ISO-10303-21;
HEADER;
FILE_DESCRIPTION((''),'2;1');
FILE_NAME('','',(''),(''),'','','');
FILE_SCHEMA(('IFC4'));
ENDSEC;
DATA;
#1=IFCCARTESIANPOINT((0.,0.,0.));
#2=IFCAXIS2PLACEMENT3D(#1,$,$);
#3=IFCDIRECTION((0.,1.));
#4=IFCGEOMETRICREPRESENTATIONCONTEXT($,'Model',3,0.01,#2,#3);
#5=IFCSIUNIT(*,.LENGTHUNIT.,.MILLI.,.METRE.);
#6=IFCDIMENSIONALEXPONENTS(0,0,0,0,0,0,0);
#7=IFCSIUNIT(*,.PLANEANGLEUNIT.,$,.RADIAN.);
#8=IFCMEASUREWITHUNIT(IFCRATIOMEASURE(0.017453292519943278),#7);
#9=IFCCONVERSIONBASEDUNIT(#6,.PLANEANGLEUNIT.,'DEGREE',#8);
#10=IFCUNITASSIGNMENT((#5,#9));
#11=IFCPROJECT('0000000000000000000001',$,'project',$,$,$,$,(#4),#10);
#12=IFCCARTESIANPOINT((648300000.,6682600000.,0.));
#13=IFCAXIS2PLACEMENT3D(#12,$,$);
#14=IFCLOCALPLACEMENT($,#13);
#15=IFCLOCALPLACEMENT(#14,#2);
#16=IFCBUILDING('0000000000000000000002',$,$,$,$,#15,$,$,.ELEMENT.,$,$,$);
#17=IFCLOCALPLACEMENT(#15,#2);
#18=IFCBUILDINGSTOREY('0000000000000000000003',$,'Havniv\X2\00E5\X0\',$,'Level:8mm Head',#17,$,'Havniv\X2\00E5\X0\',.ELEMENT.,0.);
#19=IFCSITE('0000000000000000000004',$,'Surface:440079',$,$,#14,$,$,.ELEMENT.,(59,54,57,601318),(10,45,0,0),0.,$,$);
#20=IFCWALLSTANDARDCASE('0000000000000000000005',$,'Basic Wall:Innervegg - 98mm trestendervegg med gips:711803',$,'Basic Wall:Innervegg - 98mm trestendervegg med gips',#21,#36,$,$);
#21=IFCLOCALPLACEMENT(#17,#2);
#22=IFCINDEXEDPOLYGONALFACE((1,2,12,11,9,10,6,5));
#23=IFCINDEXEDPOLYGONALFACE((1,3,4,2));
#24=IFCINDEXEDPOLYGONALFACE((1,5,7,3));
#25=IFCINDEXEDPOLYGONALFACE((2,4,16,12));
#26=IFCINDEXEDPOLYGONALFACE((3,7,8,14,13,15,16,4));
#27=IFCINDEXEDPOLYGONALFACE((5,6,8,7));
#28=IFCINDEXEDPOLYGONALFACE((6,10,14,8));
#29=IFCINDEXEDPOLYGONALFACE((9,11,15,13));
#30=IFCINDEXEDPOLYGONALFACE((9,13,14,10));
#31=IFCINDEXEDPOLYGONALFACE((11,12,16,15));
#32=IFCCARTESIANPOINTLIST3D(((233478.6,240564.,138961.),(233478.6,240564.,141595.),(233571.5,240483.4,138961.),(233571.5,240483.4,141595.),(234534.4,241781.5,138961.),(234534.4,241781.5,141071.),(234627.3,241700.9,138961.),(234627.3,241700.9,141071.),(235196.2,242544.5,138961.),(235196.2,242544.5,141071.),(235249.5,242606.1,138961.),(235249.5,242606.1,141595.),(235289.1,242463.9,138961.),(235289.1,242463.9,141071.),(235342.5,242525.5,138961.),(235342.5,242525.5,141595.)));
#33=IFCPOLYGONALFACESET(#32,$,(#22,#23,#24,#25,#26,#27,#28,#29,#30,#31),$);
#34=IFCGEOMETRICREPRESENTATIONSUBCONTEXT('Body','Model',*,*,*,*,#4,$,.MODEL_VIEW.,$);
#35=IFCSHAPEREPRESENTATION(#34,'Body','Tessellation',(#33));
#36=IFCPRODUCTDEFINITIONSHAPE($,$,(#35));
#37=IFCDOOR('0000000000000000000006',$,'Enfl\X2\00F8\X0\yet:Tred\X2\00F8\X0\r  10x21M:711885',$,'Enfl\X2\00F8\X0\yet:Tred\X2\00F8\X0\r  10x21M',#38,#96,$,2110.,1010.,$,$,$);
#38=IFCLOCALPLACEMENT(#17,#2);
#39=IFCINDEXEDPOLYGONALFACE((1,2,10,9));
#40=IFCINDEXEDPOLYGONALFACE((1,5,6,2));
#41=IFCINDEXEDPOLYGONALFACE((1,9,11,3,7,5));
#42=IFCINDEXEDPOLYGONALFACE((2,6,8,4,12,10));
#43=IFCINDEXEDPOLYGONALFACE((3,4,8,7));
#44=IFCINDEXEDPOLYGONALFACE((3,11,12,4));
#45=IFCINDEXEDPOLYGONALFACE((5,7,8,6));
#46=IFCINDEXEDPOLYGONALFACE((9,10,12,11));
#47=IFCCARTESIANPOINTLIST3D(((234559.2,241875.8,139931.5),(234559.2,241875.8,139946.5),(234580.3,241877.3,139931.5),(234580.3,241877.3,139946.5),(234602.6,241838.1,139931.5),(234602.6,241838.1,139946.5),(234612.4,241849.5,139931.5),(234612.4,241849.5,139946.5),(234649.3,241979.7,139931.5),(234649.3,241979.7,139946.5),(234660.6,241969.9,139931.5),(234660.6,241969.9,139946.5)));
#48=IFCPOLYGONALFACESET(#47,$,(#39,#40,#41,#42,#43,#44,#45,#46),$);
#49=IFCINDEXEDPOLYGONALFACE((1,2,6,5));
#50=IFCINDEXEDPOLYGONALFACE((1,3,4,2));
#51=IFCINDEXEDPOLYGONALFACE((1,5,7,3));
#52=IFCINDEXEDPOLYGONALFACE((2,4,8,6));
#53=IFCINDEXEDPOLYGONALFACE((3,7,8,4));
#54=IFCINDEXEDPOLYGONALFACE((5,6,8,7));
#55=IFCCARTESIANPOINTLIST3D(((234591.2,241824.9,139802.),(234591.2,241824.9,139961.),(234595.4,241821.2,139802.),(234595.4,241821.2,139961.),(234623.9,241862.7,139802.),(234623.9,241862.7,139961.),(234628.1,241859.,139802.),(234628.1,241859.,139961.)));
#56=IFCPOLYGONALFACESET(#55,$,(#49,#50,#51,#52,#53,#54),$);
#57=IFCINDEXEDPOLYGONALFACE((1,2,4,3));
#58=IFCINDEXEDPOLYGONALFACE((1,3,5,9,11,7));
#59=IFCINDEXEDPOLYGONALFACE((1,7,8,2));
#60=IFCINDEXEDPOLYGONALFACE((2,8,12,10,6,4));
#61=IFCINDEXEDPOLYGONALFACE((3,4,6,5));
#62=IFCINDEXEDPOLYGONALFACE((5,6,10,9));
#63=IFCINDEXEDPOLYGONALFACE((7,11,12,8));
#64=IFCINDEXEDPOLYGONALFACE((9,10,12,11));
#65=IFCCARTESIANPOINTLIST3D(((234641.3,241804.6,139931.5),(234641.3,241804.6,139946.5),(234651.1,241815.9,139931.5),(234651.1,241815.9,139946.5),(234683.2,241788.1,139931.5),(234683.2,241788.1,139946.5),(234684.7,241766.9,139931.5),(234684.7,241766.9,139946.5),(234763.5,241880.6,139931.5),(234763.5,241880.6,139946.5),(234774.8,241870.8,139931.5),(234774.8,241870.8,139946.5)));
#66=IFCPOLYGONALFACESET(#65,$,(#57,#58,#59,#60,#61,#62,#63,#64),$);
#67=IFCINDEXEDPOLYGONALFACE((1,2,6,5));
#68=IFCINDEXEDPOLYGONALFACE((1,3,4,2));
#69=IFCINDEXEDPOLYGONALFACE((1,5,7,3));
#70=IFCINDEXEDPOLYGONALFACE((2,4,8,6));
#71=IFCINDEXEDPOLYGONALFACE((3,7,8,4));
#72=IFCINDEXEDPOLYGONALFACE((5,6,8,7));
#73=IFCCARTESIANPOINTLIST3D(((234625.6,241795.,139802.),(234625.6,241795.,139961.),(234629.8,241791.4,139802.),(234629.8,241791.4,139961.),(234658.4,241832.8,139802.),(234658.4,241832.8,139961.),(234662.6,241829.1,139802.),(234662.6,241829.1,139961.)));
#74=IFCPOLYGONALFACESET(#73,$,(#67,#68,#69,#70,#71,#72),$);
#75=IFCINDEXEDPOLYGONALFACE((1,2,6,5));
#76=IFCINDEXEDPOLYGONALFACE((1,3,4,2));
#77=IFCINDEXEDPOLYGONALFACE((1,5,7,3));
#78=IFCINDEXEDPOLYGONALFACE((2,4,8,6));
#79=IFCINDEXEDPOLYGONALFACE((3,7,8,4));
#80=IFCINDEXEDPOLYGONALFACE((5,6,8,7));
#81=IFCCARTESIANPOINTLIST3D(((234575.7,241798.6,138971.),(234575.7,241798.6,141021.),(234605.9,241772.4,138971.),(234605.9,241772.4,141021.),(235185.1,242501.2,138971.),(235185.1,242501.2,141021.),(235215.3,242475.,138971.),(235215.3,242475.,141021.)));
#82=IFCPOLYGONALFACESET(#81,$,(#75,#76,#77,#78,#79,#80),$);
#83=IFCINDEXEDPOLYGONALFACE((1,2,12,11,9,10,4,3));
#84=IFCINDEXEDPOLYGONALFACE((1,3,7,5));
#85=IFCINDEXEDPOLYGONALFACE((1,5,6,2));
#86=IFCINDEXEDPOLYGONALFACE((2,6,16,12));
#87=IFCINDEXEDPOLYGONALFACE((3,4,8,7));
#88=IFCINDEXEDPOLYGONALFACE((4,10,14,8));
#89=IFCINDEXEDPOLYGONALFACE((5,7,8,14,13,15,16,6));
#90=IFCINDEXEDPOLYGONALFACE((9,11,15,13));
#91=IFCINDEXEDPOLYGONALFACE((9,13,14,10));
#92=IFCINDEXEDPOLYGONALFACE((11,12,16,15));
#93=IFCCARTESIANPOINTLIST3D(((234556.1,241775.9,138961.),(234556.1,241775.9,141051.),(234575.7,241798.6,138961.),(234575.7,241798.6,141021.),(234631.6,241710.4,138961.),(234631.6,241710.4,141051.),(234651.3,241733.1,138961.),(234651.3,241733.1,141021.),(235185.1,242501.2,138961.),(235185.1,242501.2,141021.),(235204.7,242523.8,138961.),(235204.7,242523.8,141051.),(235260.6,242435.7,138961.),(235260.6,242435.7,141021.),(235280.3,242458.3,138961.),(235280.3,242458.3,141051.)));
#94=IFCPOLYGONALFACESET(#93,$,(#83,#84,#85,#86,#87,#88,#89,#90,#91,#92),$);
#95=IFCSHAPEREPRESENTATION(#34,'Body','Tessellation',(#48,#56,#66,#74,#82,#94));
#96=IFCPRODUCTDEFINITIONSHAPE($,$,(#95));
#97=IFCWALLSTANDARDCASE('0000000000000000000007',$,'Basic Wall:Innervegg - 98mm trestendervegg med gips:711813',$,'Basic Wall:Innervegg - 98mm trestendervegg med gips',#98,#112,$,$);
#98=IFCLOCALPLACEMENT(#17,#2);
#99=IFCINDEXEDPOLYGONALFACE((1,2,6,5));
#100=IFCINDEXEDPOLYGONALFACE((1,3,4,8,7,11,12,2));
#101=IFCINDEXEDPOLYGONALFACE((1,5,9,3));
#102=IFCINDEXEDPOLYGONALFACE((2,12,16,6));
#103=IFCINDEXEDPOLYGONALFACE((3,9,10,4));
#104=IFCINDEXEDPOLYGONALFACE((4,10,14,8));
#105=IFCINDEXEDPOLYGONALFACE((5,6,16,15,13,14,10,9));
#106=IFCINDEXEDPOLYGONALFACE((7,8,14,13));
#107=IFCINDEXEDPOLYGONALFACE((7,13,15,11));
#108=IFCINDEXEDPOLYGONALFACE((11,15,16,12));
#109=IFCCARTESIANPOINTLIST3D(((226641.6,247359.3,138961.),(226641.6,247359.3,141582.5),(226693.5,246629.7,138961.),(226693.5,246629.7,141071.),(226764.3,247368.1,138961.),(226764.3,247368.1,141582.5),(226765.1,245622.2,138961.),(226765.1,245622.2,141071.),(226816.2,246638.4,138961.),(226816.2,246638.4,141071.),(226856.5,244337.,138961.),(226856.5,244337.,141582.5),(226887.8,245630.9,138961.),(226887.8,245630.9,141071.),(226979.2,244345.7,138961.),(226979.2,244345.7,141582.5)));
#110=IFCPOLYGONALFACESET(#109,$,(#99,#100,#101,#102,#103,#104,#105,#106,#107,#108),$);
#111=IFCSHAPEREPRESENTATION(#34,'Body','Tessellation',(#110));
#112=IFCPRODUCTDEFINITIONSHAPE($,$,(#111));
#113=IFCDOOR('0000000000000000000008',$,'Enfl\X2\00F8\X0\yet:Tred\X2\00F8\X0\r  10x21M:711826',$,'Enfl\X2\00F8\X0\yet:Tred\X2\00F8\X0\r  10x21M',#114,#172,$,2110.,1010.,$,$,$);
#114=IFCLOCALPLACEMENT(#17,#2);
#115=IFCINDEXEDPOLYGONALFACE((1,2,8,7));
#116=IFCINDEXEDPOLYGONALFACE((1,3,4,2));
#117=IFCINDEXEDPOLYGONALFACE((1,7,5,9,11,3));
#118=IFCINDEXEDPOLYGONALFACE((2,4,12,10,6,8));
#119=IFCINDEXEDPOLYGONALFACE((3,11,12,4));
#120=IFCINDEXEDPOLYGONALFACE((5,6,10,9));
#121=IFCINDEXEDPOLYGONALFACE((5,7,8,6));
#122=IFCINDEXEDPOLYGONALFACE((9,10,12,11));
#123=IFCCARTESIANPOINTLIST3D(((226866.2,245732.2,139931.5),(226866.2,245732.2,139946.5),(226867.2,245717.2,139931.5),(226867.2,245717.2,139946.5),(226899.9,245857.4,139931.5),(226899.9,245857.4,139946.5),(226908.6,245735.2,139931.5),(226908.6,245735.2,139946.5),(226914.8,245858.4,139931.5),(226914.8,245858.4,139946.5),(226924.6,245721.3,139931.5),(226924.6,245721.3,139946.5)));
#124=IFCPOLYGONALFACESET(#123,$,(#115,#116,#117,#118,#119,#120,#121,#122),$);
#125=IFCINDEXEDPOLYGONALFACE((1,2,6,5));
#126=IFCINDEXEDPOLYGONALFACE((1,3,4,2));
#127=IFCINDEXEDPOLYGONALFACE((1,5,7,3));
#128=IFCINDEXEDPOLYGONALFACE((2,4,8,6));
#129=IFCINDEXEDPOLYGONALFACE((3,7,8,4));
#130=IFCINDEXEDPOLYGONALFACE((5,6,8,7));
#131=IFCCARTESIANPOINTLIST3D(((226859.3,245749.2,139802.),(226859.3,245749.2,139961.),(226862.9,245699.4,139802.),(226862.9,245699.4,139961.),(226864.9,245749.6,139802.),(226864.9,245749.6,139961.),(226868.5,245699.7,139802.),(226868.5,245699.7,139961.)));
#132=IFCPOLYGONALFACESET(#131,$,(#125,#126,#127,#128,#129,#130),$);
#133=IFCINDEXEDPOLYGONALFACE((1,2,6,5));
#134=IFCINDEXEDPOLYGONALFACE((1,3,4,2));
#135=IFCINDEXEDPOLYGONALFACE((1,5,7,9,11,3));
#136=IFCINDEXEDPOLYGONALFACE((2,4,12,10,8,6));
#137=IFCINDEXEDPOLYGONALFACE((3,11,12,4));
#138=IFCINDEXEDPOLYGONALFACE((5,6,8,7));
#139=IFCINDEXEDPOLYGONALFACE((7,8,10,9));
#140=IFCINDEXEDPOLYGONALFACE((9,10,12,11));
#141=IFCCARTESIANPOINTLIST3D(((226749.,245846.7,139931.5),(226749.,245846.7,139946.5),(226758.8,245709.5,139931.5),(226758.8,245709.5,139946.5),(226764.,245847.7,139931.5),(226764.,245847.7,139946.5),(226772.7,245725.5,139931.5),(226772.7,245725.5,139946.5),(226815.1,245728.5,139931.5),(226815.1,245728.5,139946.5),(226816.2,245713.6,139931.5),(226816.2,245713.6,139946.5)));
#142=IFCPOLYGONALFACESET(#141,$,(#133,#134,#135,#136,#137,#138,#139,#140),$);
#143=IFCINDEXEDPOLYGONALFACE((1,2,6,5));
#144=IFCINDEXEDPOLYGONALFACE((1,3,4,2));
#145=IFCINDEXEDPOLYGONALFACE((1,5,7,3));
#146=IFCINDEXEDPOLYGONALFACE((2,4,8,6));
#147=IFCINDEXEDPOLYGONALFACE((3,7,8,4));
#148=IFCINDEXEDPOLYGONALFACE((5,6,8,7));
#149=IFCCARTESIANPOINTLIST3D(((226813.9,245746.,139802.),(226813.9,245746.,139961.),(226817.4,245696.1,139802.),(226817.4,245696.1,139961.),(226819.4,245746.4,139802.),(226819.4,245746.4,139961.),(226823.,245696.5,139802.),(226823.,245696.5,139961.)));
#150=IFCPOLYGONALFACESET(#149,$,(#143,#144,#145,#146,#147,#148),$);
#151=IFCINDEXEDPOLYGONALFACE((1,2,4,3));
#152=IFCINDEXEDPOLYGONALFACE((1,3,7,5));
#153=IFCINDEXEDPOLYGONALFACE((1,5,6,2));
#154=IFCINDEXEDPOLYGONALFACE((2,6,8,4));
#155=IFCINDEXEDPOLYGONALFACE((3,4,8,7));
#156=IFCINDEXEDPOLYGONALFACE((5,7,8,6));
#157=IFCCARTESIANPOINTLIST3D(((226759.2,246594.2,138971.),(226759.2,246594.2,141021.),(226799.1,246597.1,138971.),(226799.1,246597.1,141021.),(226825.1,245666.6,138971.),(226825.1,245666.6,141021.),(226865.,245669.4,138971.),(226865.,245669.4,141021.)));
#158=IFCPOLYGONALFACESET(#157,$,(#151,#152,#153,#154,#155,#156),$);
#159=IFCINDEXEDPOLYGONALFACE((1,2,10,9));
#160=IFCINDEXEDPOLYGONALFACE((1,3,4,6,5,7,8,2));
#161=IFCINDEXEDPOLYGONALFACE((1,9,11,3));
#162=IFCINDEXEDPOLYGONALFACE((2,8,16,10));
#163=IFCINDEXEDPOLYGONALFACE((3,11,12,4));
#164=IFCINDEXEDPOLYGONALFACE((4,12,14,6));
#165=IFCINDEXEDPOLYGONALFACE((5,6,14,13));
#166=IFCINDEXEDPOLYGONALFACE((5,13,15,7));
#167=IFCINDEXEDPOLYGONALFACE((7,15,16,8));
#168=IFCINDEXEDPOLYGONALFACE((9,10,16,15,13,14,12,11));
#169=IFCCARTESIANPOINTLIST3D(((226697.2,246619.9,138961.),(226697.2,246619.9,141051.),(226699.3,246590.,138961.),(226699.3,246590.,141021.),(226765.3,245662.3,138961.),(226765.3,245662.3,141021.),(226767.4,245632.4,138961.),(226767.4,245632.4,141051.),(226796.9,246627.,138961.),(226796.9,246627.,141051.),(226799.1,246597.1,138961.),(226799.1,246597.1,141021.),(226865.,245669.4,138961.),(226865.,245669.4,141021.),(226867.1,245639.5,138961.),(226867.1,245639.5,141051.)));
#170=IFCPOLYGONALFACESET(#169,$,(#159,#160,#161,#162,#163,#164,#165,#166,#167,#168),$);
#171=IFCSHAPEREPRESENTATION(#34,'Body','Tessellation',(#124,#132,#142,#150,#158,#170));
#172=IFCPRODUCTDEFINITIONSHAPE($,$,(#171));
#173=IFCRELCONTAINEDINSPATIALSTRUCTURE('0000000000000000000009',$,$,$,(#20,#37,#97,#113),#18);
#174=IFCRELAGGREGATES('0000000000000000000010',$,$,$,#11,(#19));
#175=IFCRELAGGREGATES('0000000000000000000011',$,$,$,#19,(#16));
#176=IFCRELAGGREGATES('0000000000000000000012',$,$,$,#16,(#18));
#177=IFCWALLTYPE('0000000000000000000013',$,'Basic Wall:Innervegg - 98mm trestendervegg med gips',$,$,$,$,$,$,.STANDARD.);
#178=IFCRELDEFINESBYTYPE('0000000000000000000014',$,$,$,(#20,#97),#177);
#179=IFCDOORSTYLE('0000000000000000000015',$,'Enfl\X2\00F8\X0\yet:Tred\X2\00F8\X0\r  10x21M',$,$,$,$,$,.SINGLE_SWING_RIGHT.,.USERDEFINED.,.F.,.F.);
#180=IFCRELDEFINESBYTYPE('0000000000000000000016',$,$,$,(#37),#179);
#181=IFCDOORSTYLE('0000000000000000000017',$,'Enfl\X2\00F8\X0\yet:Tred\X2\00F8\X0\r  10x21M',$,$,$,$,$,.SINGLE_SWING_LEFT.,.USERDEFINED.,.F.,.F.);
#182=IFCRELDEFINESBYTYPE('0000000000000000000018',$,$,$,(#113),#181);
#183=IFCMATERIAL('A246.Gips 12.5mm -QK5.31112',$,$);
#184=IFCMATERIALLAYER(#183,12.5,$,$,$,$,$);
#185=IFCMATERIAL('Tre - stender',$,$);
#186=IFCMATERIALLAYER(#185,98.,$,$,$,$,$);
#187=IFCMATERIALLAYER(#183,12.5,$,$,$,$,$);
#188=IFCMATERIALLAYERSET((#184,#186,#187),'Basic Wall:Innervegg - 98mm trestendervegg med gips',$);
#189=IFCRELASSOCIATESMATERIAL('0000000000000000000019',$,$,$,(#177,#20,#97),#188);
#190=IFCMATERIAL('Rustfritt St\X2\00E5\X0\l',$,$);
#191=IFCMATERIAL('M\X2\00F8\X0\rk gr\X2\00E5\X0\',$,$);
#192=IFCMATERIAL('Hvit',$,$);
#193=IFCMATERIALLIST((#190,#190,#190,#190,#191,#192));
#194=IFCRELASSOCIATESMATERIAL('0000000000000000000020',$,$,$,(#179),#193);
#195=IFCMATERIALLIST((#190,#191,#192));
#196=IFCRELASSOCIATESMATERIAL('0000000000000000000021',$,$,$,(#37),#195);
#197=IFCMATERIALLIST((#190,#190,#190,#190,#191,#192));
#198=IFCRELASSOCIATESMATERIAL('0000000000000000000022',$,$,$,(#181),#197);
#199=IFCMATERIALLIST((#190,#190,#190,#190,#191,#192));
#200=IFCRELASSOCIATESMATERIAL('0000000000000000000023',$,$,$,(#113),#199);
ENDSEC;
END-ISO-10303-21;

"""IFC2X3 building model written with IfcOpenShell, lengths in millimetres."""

from ifc_helpers import new_model, entity, si_unit, converted_unit, direction, frame, frame_2d, origin, origin_2d_with_axis, place, context, subcontext, project, spatial, polyline, rectangle, outline, extrude, clip, bounded_halfspace, source, transform, mapped, material, material_list, layer, layer_set, layer_usage, type_object, type_shapes, element, fill, save


model = new_model("IFC2X3")

# Units and contexts
model_context = context("Model", 3, precision=0.01, world=origin(), true_north=direction((0.0, 1.0)))
body_context = subcontext(model_context, "Body", "Model", "MODEL_VIEW")
ifc_project = project(units=[si_unit("LENGTHUNIT", "METRE", prefix="MILLI"), converted_unit("PLANEANGLEUNIT", "DEGREE", entity("IfcRatioMeasure", 0.017453292519943278), si_unit("PLANEANGLEUNIT", "RADIAN"), dimensions=[0, 0, 0, 0, 0, 0, 0])], contexts=[model_context])

# Site, building, storey
site_placement = place(None, frame((648300000.0, 6682600000.0, 0.0)))
site = spatial("IfcSite", under=ifc_project, at=site_placement, Name="Surface:440079", CompositionType="ELEMENT", RefLatitude=(59, 54, 57, 601318), RefLongitude=(10, 45, 0, 0), RefElevation=0.0)
building_placement = place(site_placement, origin())
building = spatial("IfcBuilding", under=site, at=building_placement, CompositionType="ELEMENT")
storey_placement = place(building_placement, origin())
storey = spatial("IfcBuildingStorey", under=building, at=storey_placement, Name="Havnivå", ObjectType="Level:8mm Head", LongName="Havnivå", CompositionType="ELEMENT", Elevation=0.0)

# Shared definitions
ifc_material_1 = material(Name="A246.Gips 12.5mm -QK5.31112")
ifc_layer_1 = layer(ifc_material_1, 12.5)
ifc_material_2 = material(Name="Tre - stender")
ifc_layer_2 = layer(ifc_material_2, 98.0)
ifc_layer_3 = layer(ifc_material_1, 12.5)
ifc_layer_set = layer_set([ifc_layer_1, ifc_layer_2, ifc_layer_3], Name="Basic Wall:Innervegg - 98mm trestendervegg med gips")
wall_type = type_object("IfcWallType", Name="Basic Wall:Innervegg - 98mm trestendervegg med gips", PredefinedType="STANDARD", material=ifc_layer_set)
ifc_material_3 = material(Name="Rustfritt Stål")
ifc_material_4 = material(Name="Mørk grå")
ifc_material_5 = material(Name="Hvit")
ifc_material_list_1 = material_list([ifc_material_3, ifc_material_3, ifc_material_3, ifc_material_3, ifc_material_4, ifc_material_5])
door_style_1 = type_object("IfcDoorStyle", Name="Enfløyet:Tredør  10x21M", ConstructionType="USERDEFINED", OperationType="SINGLE_SWING_RIGHT", ParameterTakesPrecedence=False, Sizeable=False, material=ifc_material_list_1)
shared_shape_1 = source(origin(), body_context, "Body", "SweptSolid", [
    extrude(outline(polyline([(-50.8, -33.3), (-35.8, -33.3), (-35.8, 9.2), (86.7, 9.2), (86.7, 24.2), (-50.8, 24.2), (-50.8, -33.3)])), frame((138.3, 141.9, 970.5)), (0.0, 0.0, 1.0), 15.0),
    extrude(rectangle(XDim=50.0, YDim=5.6, at=frame_2d((0.0, 0.0), x_axis=(1.0, 0.0))), frame((95.0, 105.8, 841.0), z_axis=(0.0, 0.0, 1.0), x_axis=(-1.0, 0.0, 0.0)), (0.0, 0.0, 1.0), 159.0),
    extrude(outline(polyline([(-33.3, -50.8), (24.2, -50.8), (24.2, 86.7), (9.2, 86.7), (9.2, -35.8), (-33.3, -35.8), (-33.3, -50.8)])), frame((138.3, 24.1, 970.5), z_axis=(0.0, 0.0, 1.0), x_axis=(0.0, -1.0, 0.0)), (0.0, 0.0, 1.0), 15.0),
    extrude(rectangle(XDim=5.6, YDim=50.0, at=frame_2d((0.0, 0.0), x_axis=(1.0, 0.0))), frame((95.0, 60.2, 841.0), z_axis=(0.0, 0.0, 1.0), x_axis=(0.0, 1.0, 0.0)), (0.0, 0.0, 1.0), 159.0),
    extrude(rectangle(XDim=40.0, YDim=930.0, at=origin_2d_with_axis()), frame((505.0, 83.0, 10.0), z_axis=(0.0, 0.0, 1.0), x_axis=(0.0, -1.0, 0.0)), (0.0, 0.0, 1.0), 2050.0),
    extrude(outline(polyline([(-1037.5, -495.0), (1052.5, -495.0), (1052.5, 495.0), (-1037.5, 495.0), (-1037.5, 465.0), (1022.5, 465.0), (1022.5, -465.0), (-1037.5, -465.0), (-1037.5, -495.0)])), frame((505.0, 3.0, 1037.5), z_axis=(0.0, 1.0, 0.0), x_axis=(0.0, 0.0, 1.0)), (0.0, 0.0, 1.0), 100.0),
])
type_shapes(door_style_1, [shared_shape_1])

# Wall, opening, door
ifc_layer_usage_1 = layer_usage(ifc_layer_set, "AXIS2", "NEGATIVE", 61.5)
wall_1_placement = place(storey_placement, frame((235296.0, 242565.8, 138961.0), z_axis=(0.0, 0.0, 1.0), x_axis=(-0.655187, -0.755467, 0.0)))
wall_1 = element("IfcWallStandardCase", 1, at=wall_1_placement, inside=storey, type_object=wall_type, material=ifc_layer_usage_1, Name="Basic Wall:Innervegg - 98mm trestendervegg med gips:711803", ObjectType="Basic Wall:Innervegg - 98mm trestendervegg med gips", context=body_context, shape_type="SweptSolid", body=[
    extrude(rectangle(XDim=2703.0, YDim=123.0, at=frame_2d((1351.5, 0.0), x_axis=(1.0, 0.0))), origin(), (0.0, 0.0, 1.0), 2634.0),
])
opening_1_placement = place(wall_1_placement, frame((1091.5, 61.5, 0.0)))
opening_1 = element("IfcOpeningElement", 2, at=opening_1_placement, cuts=wall_1, ObjectType="Opening", context=body_context, shape_type="SweptSolid", body=[
    extrude(rectangle(XDim=2110.0, YDim=1010.0, at=frame_2d((1055.0, 505.0), x_axis=(1.0, 0.0))), frame((0.0, 0.0, 0.0), z_axis=(0.0, -1.0, 0.0), x_axis=(0.0, 0.0, 1.0)), (0.0, 0.0, 1.0), 123.0),
])
ifc_material_list_2 = material_list([ifc_material_3, ifc_material_4, ifc_material_5])
door_1_placement = place(opening_1_placement, frame((0.0, 0.0, 0.0), z_axis=(0.0, 0.0, 1.0), x_axis=(-1.0, 0.0, 0.0)))
door_1 = element("IfcDoor", 3, at=door_1_placement, inside=storey, type_object=door_style_1, material=ifc_material_list_2, Name="Enfløyet:Tredør  10x21M:711885", ObjectType="Enfløyet:Tredør  10x21M", OverallHeight=2110.0, OverallWidth=1010.0, context=body_context, shape_type="MappedRepresentation", body=[
    mapped(shared_shape_1, transform((0.0, 0.0, 0.0), scale=1.0)),
])
fill(opening_1, door_1)

# Wall, opening, door
ifc_layer_usage_2 = layer_usage(ifc_layer_set, "AXIS2", "NEGATIVE", 61.5)
wall_2_placement = place(storey_placement, frame((226703.0, 247363.7, 138961.0), z_axis=(0.0, 0.0, 1.0), x_axis=(0.070908, -0.997483, 0.0)))
wall_2 = element("IfcWallStandardCase", 4, at=wall_2_placement, inside=storey, type_object=wall_type, material=ifc_layer_usage_2, Name="Basic Wall:Innervegg - 98mm trestendervegg med gips:711813", ObjectType="Basic Wall:Innervegg - 98mm trestendervegg med gips", context=body_context, shape_type="Clipping", body=[
    clip(extrude(rectangle(XDim=3030.0, YDim=123.0, at=frame_2d((1515.0, 0.0), x_axis=(1.0, 0.0))), origin(), (0.0, 0.0, 1.0), 2621.5), bounded_halfspace(frame((0.0, -61.5, 2621.5), z_axis=(0.0, 0.0, -1.0), x_axis=(0.0, 1.0, 0.0)), True, frame((0.0, -61.5, 2621.5)), polyline([(0.0, 0.0), (557784.0, 0.0), (595274.4, 0.0), (923544.0, 0.0), (923544.0, 37490.4), (0.0, 37490.4), (0.0, 0.0)]))),
])
opening_2_placement = place(wall_2_placement, frame((731.5, -61.5, 0.0)))
opening_2 = element("IfcOpeningElement", 5, at=opening_2_placement, cuts=wall_2, ObjectType="Opening", context=body_context, shape_type="SweptSolid", body=[
    extrude(rectangle(XDim=2110.0, YDim=1010.0, at=frame_2d((1055.0, 505.0), x_axis=(1.0, 0.0))), frame((0.0, 0.0, 0.0), z_axis=(0.0, 1.0, 0.0), x_axis=(0.0, 0.0, 1.0)), (0.0, 0.0, 1.0), 123.0),
])
ifc_material_list_3 = material_list([ifc_material_3, ifc_material_3, ifc_material_3, ifc_material_3, ifc_material_4, ifc_material_5])
ifc_material_list_4 = material_list([ifc_material_3, ifc_material_3, ifc_material_3, ifc_material_3, ifc_material_4, ifc_material_5])
door_style_2 = type_object("IfcDoorStyle", Name="Enfløyet:Tredør  10x21M", ConstructionType="USERDEFINED", OperationType="SINGLE_SWING_LEFT", ParameterTakesPrecedence=False, Sizeable=False, material=ifc_material_list_4)
shared_shape_2 = source(origin(), body_context, "Body", "SweptSolid", [
    extrude(outline(polyline([(-33.3, -50.8), (24.2, -50.8), (24.2, 86.7), (9.2, 86.7), (9.2, -35.8), (-33.3, -35.8), (-33.3, -50.8)])), frame((871.7, 121.9, 970.5), z_axis=(0.0, 0.0, 1.0), x_axis=(0.0, 1.0, 0.0)), (0.0, 0.0, 1.0), 15.0),
    extrude(rectangle(XDim=5.6, YDim=50.0, at=frame_2d((0.0, 0.0), x_axis=(1.0, 0.0))), frame((915.0, 85.8, 841.0), z_axis=(0.0, 0.0, 1.0), x_axis=(0.0, -1.0, 0.0)), (0.0, 0.0, 1.0), 159.0),
    extrude(outline(polyline([(-50.8, -33.3), (-35.8, -33.3), (-35.8, 9.2), (86.7, 9.2), (86.7, 24.2), (-50.8, 24.2), (-50.8, -33.3)])), frame((871.7, 4.1, 970.5), z_axis=(0.0, 0.0, 1.0), x_axis=(-1.0, 0.0, 0.0)), (0.0, 0.0, 1.0), 15.0),
    extrude(rectangle(XDim=50.0, YDim=5.6, at=frame_2d((0.0, 0.0), x_axis=(1.0, 0.0))), frame((915.0, 40.2, 841.0)), (0.0, 0.0, 1.0), 159.0),
    extrude(rectangle(XDim=930.0, YDim=40.0, at=origin_2d_with_axis()), frame((505.0, 63.0, 10.0), z_axis=(0.0, 0.0, 1.0), x_axis=(-1.0, 0.0, 0.0)), (0.0, 0.0, 1.0), 2050.0),
    extrude(outline(polyline([(465.0, -1037.5), (495.0, -1037.5), (495.0, 1052.5), (-495.0, 1052.5), (-495.0, -1037.5), (-465.0, -1037.5), (-465.0, 1022.5), (465.0, 1022.5), (465.0, -1037.5)])), frame((505.0, 83.0, 1037.5), z_axis=(0.0, -1.0, 0.0), x_axis=(1.0, 0.0, 0.0)), (0.0, 0.0, 1.0), 100.0),
])
type_shapes(door_style_2, [shared_shape_2])
door_2_placement = place(opening_2_placement, frame((0.0, 20.0, 0.0)))
door_2 = element("IfcDoor", 6, at=door_2_placement, inside=storey, type_object=door_style_2, material=ifc_material_list_3, Name="Enfløyet:Tredør  10x21M:711826", ObjectType="Enfløyet:Tredør  10x21M", OverallHeight=2110.0, OverallWidth=1010.0, context=body_context, shape_type="MappedRepresentation", body=[
    mapped(shared_shape_2, transform((0.0, 0.0, 0.0), scale=1.0)),
])
fill(opening_2, door_2)

save(model, "model.ifc")
